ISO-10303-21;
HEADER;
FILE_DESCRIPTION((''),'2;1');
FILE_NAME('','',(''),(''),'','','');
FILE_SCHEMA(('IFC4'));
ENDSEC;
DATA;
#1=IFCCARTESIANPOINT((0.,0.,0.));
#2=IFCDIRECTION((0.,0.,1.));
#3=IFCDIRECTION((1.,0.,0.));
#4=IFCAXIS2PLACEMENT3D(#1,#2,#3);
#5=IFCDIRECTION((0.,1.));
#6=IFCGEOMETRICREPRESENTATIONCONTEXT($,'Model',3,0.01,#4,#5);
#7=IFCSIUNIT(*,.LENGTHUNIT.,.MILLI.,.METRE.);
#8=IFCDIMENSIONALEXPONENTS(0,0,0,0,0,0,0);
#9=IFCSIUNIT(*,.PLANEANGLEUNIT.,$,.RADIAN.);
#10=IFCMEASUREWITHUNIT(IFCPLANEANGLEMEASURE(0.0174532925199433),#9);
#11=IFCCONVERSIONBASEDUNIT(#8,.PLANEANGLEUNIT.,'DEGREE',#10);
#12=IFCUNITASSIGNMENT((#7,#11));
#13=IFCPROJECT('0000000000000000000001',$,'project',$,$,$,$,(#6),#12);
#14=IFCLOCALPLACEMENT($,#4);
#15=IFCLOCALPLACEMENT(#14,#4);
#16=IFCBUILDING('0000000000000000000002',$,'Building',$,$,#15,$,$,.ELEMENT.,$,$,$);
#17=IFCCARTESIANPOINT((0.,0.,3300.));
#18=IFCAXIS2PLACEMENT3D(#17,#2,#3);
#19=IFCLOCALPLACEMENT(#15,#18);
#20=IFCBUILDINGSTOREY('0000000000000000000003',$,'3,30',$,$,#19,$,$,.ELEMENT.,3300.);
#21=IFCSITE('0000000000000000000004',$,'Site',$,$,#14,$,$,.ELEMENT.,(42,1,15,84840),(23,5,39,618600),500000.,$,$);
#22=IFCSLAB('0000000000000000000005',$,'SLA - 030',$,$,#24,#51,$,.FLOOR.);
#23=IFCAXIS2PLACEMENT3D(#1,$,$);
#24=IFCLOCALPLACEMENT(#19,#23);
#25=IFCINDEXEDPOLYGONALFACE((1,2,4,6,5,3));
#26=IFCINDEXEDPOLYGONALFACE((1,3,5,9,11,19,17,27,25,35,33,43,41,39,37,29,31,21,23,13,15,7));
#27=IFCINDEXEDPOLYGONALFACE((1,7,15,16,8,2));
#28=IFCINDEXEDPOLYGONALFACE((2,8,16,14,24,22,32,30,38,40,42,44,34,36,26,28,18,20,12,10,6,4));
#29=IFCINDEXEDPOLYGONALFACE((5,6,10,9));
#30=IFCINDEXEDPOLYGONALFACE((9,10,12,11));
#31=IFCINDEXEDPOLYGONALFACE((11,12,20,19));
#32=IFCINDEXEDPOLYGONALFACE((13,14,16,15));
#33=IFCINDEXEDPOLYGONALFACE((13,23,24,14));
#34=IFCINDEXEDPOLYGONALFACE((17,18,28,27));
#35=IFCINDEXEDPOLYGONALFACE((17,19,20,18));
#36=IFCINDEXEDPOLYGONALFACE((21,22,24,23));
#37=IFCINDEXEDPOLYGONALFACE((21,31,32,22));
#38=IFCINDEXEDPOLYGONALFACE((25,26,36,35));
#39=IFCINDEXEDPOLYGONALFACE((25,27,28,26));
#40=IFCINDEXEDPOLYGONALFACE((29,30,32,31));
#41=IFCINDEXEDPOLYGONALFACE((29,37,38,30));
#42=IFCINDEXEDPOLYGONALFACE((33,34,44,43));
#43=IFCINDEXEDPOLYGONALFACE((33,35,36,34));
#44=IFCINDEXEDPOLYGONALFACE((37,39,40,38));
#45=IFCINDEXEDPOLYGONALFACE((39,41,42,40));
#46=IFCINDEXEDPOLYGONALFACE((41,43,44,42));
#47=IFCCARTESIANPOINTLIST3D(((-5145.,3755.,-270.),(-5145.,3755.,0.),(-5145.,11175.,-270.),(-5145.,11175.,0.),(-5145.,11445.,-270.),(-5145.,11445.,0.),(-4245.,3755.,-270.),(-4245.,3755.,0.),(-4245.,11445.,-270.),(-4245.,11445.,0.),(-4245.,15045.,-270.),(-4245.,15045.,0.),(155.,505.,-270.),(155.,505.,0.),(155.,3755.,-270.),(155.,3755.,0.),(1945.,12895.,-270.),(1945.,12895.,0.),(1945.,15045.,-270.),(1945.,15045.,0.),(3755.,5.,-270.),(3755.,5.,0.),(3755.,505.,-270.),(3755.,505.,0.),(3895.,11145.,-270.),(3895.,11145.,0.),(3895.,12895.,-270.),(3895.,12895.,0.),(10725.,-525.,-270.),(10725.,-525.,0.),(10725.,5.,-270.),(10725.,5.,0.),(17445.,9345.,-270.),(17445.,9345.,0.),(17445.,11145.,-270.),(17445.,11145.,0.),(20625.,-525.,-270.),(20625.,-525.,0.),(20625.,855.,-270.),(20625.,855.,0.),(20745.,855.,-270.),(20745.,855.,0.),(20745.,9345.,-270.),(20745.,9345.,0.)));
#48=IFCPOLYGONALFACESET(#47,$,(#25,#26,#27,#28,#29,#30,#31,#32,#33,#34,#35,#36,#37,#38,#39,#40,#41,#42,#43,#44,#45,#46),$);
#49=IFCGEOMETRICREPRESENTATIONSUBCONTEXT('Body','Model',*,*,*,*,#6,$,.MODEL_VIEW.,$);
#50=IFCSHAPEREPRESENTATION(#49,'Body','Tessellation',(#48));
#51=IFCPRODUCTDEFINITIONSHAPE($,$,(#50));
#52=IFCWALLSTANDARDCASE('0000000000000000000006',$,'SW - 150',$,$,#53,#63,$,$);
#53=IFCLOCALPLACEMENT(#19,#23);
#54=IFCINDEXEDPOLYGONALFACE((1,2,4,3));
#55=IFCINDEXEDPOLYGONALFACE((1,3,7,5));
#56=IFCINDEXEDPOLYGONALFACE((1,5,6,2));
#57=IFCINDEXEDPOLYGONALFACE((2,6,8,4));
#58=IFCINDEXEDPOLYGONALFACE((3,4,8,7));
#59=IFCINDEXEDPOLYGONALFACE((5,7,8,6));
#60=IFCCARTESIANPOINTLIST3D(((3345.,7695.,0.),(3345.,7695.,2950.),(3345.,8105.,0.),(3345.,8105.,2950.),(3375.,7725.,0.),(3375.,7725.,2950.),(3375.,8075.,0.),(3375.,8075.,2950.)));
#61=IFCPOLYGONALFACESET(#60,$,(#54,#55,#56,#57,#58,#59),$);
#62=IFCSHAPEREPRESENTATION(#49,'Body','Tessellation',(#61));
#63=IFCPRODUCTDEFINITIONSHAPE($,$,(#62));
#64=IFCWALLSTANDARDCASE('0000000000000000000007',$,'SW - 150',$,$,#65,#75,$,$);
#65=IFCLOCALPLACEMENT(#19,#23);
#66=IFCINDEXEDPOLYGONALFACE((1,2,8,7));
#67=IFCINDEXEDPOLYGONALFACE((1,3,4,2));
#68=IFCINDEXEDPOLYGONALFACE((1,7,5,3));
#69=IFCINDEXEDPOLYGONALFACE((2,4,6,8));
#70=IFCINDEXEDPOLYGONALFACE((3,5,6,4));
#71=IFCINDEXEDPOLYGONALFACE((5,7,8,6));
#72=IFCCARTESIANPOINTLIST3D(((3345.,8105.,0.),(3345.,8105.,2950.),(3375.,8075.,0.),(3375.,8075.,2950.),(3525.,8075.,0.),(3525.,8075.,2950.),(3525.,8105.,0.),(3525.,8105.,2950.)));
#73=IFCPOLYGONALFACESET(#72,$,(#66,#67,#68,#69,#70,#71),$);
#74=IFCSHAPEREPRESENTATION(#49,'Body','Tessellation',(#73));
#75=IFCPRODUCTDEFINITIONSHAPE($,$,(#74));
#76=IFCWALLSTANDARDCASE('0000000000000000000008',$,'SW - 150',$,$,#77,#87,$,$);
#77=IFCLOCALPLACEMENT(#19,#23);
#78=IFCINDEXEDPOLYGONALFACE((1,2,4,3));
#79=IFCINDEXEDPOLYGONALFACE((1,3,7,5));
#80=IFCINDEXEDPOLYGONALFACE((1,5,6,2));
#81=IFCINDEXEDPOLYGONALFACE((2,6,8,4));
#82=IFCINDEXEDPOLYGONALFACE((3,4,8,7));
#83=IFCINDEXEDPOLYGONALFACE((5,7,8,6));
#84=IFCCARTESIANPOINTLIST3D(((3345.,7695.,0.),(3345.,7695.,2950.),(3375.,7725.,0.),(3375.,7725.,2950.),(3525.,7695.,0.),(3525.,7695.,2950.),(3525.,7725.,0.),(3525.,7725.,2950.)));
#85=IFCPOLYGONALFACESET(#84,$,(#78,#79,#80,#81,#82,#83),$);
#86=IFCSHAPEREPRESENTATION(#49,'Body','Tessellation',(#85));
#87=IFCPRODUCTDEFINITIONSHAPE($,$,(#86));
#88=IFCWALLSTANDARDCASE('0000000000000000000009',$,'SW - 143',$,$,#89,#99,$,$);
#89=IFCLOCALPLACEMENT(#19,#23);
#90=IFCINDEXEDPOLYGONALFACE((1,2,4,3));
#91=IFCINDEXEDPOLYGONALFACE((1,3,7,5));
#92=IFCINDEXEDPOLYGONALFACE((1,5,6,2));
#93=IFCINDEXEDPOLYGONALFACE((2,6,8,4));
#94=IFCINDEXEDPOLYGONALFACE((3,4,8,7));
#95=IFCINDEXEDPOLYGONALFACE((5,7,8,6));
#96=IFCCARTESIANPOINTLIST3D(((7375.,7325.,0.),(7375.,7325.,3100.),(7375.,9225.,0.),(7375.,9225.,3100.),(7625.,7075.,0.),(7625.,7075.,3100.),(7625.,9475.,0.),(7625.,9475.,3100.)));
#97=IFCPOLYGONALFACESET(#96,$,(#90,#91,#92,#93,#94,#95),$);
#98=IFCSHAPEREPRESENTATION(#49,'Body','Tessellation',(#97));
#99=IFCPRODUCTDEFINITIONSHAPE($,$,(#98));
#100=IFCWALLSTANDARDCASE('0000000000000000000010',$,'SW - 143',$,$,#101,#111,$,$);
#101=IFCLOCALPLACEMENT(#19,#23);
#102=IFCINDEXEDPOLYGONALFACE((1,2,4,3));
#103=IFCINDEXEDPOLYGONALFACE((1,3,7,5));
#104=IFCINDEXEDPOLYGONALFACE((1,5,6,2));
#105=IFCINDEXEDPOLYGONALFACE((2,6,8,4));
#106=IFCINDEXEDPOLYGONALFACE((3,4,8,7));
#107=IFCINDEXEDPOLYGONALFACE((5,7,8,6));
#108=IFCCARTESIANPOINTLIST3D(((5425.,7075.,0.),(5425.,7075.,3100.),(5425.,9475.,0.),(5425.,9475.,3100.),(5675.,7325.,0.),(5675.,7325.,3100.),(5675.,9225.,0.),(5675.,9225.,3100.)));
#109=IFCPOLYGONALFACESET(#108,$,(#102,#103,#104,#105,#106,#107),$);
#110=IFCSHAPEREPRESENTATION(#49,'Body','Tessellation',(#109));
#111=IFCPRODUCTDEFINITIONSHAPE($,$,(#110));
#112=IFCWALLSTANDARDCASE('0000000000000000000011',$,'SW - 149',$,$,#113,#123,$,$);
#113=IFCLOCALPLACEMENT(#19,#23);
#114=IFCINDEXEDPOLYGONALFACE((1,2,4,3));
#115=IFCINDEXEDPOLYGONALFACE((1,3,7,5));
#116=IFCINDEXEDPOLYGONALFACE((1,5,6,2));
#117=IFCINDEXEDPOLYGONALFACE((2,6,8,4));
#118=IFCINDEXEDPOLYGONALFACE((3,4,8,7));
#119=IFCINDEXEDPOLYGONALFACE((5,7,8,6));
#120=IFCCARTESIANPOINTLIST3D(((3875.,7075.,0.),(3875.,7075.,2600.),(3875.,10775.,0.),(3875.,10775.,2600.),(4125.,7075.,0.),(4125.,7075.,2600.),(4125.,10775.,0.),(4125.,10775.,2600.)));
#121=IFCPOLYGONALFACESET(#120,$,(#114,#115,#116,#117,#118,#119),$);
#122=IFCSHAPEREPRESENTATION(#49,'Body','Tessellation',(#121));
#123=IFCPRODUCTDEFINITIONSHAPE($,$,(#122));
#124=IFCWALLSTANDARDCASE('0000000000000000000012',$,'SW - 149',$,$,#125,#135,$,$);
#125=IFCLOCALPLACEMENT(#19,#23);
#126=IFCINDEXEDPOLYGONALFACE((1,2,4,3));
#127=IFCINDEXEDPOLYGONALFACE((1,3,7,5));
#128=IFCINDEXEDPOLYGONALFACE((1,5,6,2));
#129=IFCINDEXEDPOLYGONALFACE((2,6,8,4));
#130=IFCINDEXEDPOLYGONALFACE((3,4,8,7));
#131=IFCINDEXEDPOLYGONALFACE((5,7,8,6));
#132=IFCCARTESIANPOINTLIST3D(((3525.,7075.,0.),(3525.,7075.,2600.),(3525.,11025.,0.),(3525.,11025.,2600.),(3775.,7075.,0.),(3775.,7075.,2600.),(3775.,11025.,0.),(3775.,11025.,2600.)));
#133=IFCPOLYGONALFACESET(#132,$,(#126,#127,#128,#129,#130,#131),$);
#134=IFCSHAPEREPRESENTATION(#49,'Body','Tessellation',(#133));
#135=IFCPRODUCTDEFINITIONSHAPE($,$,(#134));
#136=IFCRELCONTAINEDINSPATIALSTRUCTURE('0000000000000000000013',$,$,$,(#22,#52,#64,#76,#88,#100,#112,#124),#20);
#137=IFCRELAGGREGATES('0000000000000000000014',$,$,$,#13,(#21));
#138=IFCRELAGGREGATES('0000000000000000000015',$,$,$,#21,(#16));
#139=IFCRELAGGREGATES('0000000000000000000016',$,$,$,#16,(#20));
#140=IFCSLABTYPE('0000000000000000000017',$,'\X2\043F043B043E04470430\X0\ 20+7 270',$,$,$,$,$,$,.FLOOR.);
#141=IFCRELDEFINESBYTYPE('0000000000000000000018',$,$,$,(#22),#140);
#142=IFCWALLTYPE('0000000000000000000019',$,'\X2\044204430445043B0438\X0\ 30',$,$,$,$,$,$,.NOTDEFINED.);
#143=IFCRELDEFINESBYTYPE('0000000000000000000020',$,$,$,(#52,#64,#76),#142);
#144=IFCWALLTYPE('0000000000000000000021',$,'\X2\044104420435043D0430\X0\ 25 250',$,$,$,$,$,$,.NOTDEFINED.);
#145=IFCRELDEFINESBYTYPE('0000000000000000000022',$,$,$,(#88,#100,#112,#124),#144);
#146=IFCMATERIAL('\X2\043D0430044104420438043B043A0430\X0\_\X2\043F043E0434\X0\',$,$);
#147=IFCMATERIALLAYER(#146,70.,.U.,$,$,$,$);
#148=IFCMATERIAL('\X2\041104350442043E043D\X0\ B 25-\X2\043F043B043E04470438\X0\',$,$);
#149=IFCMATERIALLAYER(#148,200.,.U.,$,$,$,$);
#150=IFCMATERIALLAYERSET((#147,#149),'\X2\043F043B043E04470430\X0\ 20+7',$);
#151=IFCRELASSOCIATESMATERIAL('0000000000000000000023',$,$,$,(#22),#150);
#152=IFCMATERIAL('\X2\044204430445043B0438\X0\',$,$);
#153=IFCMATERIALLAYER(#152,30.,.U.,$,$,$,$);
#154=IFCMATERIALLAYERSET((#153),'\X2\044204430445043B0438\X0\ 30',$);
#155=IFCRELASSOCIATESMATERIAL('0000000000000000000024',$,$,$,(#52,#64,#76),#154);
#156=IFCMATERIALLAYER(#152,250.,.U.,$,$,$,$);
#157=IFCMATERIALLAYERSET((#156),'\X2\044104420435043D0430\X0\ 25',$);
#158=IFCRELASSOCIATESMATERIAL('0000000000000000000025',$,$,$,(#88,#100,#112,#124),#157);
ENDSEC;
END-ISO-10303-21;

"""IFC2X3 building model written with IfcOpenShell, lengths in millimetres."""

from ifc_helpers import new_model, entity, si_unit, converted_unit, direction, frame, origin_with_axes, place, context, subcontext, project, spatial, polyline, outline, extrude, material, layer, layer_set, layer_usage, type_object, element, save


model = new_model("IFC2X3")

# Units and contexts
model_context = context("Model", 3, precision=0.01, world=origin_with_axes(), true_north=direction((0.0, 1.0)))
body_context = subcontext(model_context, "Body", "Model", "MODEL_VIEW")
ifc_project = project(units=[si_unit("LENGTHUNIT", "METRE", prefix="MILLI"), converted_unit("PLANEANGLEUNIT", "DEGREE", entity("IfcPlaneAngleMeasure", 0.0174532925199433), si_unit("PLANEANGLEUNIT", "RADIAN"), dimensions=[0, 0, 0, 0, 0, 0, 0])], contexts=[model_context])

# Site, building, storey
site_placement = place(None, origin_with_axes())
site = spatial("IfcSite", under=ifc_project, at=site_placement, Name="Site", CompositionType="ELEMENT", RefLatitude=(42, 1, 15, 84840), RefLongitude=(23, 5, 39, 618600), RefElevation=500000.0)
building_placement = place(site_placement, origin_with_axes())
building = spatial("IfcBuilding", under=site, at=building_placement, Name="Building", CompositionType="ELEMENT")
storey_placement = place(building_placement, frame((0.0, 0.0, 3300.0), z_axis=(0.0, 0.0, 1.0), x_axis=(1.0, 0.0, 0.0)))
storey = spatial("IfcBuildingStorey", under=building, at=storey_placement, Name="3,30", CompositionType="ELEMENT", Elevation=3300.0)

# Slab
ifc_material_1 = material(Name="настилка_под")
ifc_layer_1 = layer(ifc_material_1, 70.0, ventilated="UNKNOWN")
ifc_material_2 = material(Name="Бетон B 25-плочи")
ifc_layer_2 = layer(ifc_material_2, 200.0, ventilated="UNKNOWN")
ifc_layer_set_1 = layer_set([ifc_layer_1, ifc_layer_2], Name="плоча 20+7")
ifc_layer_usage_1 = layer_usage(ifc_layer_set_1, "AXIS3", "NEGATIVE", 270.0)
slab_type = type_object("IfcSlabType", Name="плоча 20+7 270", PredefinedType="FLOOR")
slab_placement = place(storey_placement, frame((-4245.0, 15045.0, 0.0), z_axis=(0.0, 0.0, 1.0), x_axis=(1.0, 0.0, 0.0)))
element("IfcSlab", 1, at=slab_placement, inside=storey, type_object=slab_type, material=ifc_layer_usage_1, Name="SLA - 030", PredefinedType="FLOOR", context=body_context, shape_type="SweptSolid", body=[
    extrude(outline(polyline([(0.0, 0.0), (0.0, -3600.0), (-900.0, -3600.0), (-900.0, -3870.0), (-900.0, -11290.0), (0.0, -11290.0), (4400.0, -11290.0), (4400.0, -14540.0), (8000.0, -14540.0), (8000.0, -15040.0), (14970.0, -15040.0), (14970.0, -15570.0), (24870.0, -15570.0), (24870.0, -14190.0), (24990.0, -14190.0), (24990.0, -5700.0), (21690.0, -5700.0), (21690.0, -3900.0), (8140.0, -3900.0), (8140.0, -2150.0), (6190.0, -2150.0), (6190.0, 0.0), (0.0, 0.0)])), frame((0.0, 0.0, -270.0), z_axis=(0.0, 0.0, 1.0), x_axis=(1.0, 0.0, 0.0)), (0.0, 0.0, 1.0), 270.0),
])

# Shared definitions
ifc_material_3 = material(Name="тухли")

# Walls
ifc_layer_3 = layer(ifc_material_3, 30.0, ventilated="UNKNOWN")
ifc_layer_set_2 = layer_set([ifc_layer_3], Name="тухли 30")
ifc_layer_usage_2 = layer_usage(ifc_layer_set_2, "AXIS2", "NEGATIVE", 0.0)
wall_type_1 = type_object("IfcWallType", Name="тухли 30", PredefinedType="NOTDEFINED")
wall_1_placement = place(storey_placement, frame((3345.0, 7695.0, 0.0), z_axis=(0.0, 0.0, 1.0), x_axis=(0.0, 1.0, 0.0)))
element("IfcWallStandardCase", 2, at=wall_1_placement, inside=storey, type_object=wall_type_1, material=ifc_layer_usage_2, Name="SW - 150", context=body_context, shape_type="SweptSolid", body=[
    extrude(outline(polyline([(30.0, -30.0), (380.0, -30.0), (410.0, 0.0), (0.0, 0.0), (30.0, -30.0)])), origin_with_axes(), (0.0, 0.0, 1.0), 2950.0),
])
ifc_layer_usage_3 = layer_usage(ifc_layer_set_2, "AXIS2", "POSITIVE", 0.0)
wall_2_placement = place(storey_placement, frame((3525.0, 8105.0, 0.0), z_axis=(0.0, 0.0, 1.0), x_axis=(-1.0, 0.0, 0.0)))
element("IfcWallStandardCase", 3, at=wall_2_placement, inside=storey, type_object=wall_type_1, material=ifc_layer_usage_3, Name="SW - 150", context=body_context, shape_type="SweptSolid", body=[
    extrude(outline(polyline([(0.0, 0.0), (180.0, 0.0), (150.0, 30.0), (0.0, 30.0), (0.0, 0.0)])), origin_with_axes(), (0.0, 0.0, 1.0), 2950.0),
])
ifc_layer_usage_4 = layer_usage(ifc_layer_set_2, "AXIS2", "NEGATIVE", 0.0)
wall_3_placement = place(storey_placement, frame((3525.0, 7695.0, 0.0), z_axis=(0.0, 0.0, 1.0), x_axis=(-1.0, 0.0, 0.0)))
element("IfcWallStandardCase", 4, at=wall_3_placement, inside=storey, type_object=wall_type_1, material=ifc_layer_usage_4, Name="SW - 150", context=body_context, shape_type="SweptSolid", body=[
    extrude(outline(polyline([(0.0, -30.0), (150.0, -30.0), (180.0, 0.0), (0.0, 0.0), (0.0, -30.0)])), origin_with_axes(), (0.0, 0.0, 1.0), 2950.0),
])
ifc_layer_4 = layer(ifc_material_3, 250.0, ventilated="UNKNOWN")
ifc_layer_set_3 = layer_set([ifc_layer_4], Name="стена 25")
ifc_layer_usage_5 = layer_usage(ifc_layer_set_3, "AXIS2", "NEGATIVE", 0.0)
wall_type_2 = type_object("IfcWallType", Name="стена 25 250", PredefinedType="NOTDEFINED")
wall_4_placement = place(storey_placement, frame((7625.0, 9475.0, 0.0), z_axis=(0.0, 0.0, 1.0), x_axis=(0.0, -1.0, 0.0)))
element("IfcWallStandardCase", 5, at=wall_4_placement, inside=storey, type_object=wall_type_2, material=ifc_layer_usage_5, Name="SW - 143", context=body_context, shape_type="SweptSolid", body=[
    extrude(outline(polyline([(250.0, -250.0), (2150.0, -250.0), (2400.0, 0.0), (0.0, 0.0), (250.0, -250.0)])), origin_with_axes(), (0.0, 0.0, 1.0), 3100.0),
])
ifc_layer_usage_6 = layer_usage(ifc_layer_set_3, "AXIS2", "POSITIVE", 0.0)
wall_5_placement = place(storey_placement, frame((5425.0, 9475.0, 0.0), z_axis=(0.0, 0.0, 1.0), x_axis=(0.0, -1.0, 0.0)))
element("IfcWallStandardCase", 6, at=wall_5_placement, inside=storey, type_object=wall_type_2, material=ifc_layer_usage_6, Name="SW - 143", context=body_context, shape_type="SweptSolid", body=[
    extrude(outline(polyline([(0.0, 0.0), (2400.0, 0.0), (2150.0, 250.0), (250.0, 250.0), (0.0, 0.0)])), origin_with_axes(), (0.0, 0.0, 1.0), 3100.0),
])
ifc_layer_usage_7 = layer_usage(ifc_layer_set_3, "AXIS2", "NEGATIVE", 0.0)
wall_6_placement = place(storey_placement, frame((3875.0, 7075.0, 0.0), z_axis=(0.0, 0.0, 1.0), x_axis=(0.0, 1.0, 0.0)))
element("IfcWallStandardCase", 7, at=wall_6_placement, inside=storey, type_object=wall_type_2, material=ifc_layer_usage_7, Name="SW - 149", context=body_context, shape_type="SweptSolid", body=[
    extrude(outline(polyline([(0.0, -250.0), (3700.0, -250.0), (3700.0, 0.0), (0.0, 0.0), (0.0, -250.0)])), origin_with_axes(), (0.0, 0.0, 1.0), 2600.0),
])
ifc_layer_usage_8 = layer_usage(ifc_layer_set_3, "AXIS2", "NEGATIVE", 0.0)
wall_7_placement = place(storey_placement, frame((3525.0, 7075.0, 0.0), z_axis=(0.0, 0.0, 1.0), x_axis=(0.0, 1.0, 0.0)))
element("IfcWallStandardCase", 8, at=wall_7_placement, inside=storey, type_object=wall_type_2, material=ifc_layer_usage_8, Name="SW - 149", context=body_context, shape_type="SweptSolid", body=[
    extrude(outline(polyline([(0.0, -250.0), (3950.0, -250.0), (3950.0, 0.0), (0.0, 0.0), (0.0, -250.0)])), origin_with_axes(), (0.0, 0.0, 1.0), 2600.0),
])

save(model, "model.ifc")
